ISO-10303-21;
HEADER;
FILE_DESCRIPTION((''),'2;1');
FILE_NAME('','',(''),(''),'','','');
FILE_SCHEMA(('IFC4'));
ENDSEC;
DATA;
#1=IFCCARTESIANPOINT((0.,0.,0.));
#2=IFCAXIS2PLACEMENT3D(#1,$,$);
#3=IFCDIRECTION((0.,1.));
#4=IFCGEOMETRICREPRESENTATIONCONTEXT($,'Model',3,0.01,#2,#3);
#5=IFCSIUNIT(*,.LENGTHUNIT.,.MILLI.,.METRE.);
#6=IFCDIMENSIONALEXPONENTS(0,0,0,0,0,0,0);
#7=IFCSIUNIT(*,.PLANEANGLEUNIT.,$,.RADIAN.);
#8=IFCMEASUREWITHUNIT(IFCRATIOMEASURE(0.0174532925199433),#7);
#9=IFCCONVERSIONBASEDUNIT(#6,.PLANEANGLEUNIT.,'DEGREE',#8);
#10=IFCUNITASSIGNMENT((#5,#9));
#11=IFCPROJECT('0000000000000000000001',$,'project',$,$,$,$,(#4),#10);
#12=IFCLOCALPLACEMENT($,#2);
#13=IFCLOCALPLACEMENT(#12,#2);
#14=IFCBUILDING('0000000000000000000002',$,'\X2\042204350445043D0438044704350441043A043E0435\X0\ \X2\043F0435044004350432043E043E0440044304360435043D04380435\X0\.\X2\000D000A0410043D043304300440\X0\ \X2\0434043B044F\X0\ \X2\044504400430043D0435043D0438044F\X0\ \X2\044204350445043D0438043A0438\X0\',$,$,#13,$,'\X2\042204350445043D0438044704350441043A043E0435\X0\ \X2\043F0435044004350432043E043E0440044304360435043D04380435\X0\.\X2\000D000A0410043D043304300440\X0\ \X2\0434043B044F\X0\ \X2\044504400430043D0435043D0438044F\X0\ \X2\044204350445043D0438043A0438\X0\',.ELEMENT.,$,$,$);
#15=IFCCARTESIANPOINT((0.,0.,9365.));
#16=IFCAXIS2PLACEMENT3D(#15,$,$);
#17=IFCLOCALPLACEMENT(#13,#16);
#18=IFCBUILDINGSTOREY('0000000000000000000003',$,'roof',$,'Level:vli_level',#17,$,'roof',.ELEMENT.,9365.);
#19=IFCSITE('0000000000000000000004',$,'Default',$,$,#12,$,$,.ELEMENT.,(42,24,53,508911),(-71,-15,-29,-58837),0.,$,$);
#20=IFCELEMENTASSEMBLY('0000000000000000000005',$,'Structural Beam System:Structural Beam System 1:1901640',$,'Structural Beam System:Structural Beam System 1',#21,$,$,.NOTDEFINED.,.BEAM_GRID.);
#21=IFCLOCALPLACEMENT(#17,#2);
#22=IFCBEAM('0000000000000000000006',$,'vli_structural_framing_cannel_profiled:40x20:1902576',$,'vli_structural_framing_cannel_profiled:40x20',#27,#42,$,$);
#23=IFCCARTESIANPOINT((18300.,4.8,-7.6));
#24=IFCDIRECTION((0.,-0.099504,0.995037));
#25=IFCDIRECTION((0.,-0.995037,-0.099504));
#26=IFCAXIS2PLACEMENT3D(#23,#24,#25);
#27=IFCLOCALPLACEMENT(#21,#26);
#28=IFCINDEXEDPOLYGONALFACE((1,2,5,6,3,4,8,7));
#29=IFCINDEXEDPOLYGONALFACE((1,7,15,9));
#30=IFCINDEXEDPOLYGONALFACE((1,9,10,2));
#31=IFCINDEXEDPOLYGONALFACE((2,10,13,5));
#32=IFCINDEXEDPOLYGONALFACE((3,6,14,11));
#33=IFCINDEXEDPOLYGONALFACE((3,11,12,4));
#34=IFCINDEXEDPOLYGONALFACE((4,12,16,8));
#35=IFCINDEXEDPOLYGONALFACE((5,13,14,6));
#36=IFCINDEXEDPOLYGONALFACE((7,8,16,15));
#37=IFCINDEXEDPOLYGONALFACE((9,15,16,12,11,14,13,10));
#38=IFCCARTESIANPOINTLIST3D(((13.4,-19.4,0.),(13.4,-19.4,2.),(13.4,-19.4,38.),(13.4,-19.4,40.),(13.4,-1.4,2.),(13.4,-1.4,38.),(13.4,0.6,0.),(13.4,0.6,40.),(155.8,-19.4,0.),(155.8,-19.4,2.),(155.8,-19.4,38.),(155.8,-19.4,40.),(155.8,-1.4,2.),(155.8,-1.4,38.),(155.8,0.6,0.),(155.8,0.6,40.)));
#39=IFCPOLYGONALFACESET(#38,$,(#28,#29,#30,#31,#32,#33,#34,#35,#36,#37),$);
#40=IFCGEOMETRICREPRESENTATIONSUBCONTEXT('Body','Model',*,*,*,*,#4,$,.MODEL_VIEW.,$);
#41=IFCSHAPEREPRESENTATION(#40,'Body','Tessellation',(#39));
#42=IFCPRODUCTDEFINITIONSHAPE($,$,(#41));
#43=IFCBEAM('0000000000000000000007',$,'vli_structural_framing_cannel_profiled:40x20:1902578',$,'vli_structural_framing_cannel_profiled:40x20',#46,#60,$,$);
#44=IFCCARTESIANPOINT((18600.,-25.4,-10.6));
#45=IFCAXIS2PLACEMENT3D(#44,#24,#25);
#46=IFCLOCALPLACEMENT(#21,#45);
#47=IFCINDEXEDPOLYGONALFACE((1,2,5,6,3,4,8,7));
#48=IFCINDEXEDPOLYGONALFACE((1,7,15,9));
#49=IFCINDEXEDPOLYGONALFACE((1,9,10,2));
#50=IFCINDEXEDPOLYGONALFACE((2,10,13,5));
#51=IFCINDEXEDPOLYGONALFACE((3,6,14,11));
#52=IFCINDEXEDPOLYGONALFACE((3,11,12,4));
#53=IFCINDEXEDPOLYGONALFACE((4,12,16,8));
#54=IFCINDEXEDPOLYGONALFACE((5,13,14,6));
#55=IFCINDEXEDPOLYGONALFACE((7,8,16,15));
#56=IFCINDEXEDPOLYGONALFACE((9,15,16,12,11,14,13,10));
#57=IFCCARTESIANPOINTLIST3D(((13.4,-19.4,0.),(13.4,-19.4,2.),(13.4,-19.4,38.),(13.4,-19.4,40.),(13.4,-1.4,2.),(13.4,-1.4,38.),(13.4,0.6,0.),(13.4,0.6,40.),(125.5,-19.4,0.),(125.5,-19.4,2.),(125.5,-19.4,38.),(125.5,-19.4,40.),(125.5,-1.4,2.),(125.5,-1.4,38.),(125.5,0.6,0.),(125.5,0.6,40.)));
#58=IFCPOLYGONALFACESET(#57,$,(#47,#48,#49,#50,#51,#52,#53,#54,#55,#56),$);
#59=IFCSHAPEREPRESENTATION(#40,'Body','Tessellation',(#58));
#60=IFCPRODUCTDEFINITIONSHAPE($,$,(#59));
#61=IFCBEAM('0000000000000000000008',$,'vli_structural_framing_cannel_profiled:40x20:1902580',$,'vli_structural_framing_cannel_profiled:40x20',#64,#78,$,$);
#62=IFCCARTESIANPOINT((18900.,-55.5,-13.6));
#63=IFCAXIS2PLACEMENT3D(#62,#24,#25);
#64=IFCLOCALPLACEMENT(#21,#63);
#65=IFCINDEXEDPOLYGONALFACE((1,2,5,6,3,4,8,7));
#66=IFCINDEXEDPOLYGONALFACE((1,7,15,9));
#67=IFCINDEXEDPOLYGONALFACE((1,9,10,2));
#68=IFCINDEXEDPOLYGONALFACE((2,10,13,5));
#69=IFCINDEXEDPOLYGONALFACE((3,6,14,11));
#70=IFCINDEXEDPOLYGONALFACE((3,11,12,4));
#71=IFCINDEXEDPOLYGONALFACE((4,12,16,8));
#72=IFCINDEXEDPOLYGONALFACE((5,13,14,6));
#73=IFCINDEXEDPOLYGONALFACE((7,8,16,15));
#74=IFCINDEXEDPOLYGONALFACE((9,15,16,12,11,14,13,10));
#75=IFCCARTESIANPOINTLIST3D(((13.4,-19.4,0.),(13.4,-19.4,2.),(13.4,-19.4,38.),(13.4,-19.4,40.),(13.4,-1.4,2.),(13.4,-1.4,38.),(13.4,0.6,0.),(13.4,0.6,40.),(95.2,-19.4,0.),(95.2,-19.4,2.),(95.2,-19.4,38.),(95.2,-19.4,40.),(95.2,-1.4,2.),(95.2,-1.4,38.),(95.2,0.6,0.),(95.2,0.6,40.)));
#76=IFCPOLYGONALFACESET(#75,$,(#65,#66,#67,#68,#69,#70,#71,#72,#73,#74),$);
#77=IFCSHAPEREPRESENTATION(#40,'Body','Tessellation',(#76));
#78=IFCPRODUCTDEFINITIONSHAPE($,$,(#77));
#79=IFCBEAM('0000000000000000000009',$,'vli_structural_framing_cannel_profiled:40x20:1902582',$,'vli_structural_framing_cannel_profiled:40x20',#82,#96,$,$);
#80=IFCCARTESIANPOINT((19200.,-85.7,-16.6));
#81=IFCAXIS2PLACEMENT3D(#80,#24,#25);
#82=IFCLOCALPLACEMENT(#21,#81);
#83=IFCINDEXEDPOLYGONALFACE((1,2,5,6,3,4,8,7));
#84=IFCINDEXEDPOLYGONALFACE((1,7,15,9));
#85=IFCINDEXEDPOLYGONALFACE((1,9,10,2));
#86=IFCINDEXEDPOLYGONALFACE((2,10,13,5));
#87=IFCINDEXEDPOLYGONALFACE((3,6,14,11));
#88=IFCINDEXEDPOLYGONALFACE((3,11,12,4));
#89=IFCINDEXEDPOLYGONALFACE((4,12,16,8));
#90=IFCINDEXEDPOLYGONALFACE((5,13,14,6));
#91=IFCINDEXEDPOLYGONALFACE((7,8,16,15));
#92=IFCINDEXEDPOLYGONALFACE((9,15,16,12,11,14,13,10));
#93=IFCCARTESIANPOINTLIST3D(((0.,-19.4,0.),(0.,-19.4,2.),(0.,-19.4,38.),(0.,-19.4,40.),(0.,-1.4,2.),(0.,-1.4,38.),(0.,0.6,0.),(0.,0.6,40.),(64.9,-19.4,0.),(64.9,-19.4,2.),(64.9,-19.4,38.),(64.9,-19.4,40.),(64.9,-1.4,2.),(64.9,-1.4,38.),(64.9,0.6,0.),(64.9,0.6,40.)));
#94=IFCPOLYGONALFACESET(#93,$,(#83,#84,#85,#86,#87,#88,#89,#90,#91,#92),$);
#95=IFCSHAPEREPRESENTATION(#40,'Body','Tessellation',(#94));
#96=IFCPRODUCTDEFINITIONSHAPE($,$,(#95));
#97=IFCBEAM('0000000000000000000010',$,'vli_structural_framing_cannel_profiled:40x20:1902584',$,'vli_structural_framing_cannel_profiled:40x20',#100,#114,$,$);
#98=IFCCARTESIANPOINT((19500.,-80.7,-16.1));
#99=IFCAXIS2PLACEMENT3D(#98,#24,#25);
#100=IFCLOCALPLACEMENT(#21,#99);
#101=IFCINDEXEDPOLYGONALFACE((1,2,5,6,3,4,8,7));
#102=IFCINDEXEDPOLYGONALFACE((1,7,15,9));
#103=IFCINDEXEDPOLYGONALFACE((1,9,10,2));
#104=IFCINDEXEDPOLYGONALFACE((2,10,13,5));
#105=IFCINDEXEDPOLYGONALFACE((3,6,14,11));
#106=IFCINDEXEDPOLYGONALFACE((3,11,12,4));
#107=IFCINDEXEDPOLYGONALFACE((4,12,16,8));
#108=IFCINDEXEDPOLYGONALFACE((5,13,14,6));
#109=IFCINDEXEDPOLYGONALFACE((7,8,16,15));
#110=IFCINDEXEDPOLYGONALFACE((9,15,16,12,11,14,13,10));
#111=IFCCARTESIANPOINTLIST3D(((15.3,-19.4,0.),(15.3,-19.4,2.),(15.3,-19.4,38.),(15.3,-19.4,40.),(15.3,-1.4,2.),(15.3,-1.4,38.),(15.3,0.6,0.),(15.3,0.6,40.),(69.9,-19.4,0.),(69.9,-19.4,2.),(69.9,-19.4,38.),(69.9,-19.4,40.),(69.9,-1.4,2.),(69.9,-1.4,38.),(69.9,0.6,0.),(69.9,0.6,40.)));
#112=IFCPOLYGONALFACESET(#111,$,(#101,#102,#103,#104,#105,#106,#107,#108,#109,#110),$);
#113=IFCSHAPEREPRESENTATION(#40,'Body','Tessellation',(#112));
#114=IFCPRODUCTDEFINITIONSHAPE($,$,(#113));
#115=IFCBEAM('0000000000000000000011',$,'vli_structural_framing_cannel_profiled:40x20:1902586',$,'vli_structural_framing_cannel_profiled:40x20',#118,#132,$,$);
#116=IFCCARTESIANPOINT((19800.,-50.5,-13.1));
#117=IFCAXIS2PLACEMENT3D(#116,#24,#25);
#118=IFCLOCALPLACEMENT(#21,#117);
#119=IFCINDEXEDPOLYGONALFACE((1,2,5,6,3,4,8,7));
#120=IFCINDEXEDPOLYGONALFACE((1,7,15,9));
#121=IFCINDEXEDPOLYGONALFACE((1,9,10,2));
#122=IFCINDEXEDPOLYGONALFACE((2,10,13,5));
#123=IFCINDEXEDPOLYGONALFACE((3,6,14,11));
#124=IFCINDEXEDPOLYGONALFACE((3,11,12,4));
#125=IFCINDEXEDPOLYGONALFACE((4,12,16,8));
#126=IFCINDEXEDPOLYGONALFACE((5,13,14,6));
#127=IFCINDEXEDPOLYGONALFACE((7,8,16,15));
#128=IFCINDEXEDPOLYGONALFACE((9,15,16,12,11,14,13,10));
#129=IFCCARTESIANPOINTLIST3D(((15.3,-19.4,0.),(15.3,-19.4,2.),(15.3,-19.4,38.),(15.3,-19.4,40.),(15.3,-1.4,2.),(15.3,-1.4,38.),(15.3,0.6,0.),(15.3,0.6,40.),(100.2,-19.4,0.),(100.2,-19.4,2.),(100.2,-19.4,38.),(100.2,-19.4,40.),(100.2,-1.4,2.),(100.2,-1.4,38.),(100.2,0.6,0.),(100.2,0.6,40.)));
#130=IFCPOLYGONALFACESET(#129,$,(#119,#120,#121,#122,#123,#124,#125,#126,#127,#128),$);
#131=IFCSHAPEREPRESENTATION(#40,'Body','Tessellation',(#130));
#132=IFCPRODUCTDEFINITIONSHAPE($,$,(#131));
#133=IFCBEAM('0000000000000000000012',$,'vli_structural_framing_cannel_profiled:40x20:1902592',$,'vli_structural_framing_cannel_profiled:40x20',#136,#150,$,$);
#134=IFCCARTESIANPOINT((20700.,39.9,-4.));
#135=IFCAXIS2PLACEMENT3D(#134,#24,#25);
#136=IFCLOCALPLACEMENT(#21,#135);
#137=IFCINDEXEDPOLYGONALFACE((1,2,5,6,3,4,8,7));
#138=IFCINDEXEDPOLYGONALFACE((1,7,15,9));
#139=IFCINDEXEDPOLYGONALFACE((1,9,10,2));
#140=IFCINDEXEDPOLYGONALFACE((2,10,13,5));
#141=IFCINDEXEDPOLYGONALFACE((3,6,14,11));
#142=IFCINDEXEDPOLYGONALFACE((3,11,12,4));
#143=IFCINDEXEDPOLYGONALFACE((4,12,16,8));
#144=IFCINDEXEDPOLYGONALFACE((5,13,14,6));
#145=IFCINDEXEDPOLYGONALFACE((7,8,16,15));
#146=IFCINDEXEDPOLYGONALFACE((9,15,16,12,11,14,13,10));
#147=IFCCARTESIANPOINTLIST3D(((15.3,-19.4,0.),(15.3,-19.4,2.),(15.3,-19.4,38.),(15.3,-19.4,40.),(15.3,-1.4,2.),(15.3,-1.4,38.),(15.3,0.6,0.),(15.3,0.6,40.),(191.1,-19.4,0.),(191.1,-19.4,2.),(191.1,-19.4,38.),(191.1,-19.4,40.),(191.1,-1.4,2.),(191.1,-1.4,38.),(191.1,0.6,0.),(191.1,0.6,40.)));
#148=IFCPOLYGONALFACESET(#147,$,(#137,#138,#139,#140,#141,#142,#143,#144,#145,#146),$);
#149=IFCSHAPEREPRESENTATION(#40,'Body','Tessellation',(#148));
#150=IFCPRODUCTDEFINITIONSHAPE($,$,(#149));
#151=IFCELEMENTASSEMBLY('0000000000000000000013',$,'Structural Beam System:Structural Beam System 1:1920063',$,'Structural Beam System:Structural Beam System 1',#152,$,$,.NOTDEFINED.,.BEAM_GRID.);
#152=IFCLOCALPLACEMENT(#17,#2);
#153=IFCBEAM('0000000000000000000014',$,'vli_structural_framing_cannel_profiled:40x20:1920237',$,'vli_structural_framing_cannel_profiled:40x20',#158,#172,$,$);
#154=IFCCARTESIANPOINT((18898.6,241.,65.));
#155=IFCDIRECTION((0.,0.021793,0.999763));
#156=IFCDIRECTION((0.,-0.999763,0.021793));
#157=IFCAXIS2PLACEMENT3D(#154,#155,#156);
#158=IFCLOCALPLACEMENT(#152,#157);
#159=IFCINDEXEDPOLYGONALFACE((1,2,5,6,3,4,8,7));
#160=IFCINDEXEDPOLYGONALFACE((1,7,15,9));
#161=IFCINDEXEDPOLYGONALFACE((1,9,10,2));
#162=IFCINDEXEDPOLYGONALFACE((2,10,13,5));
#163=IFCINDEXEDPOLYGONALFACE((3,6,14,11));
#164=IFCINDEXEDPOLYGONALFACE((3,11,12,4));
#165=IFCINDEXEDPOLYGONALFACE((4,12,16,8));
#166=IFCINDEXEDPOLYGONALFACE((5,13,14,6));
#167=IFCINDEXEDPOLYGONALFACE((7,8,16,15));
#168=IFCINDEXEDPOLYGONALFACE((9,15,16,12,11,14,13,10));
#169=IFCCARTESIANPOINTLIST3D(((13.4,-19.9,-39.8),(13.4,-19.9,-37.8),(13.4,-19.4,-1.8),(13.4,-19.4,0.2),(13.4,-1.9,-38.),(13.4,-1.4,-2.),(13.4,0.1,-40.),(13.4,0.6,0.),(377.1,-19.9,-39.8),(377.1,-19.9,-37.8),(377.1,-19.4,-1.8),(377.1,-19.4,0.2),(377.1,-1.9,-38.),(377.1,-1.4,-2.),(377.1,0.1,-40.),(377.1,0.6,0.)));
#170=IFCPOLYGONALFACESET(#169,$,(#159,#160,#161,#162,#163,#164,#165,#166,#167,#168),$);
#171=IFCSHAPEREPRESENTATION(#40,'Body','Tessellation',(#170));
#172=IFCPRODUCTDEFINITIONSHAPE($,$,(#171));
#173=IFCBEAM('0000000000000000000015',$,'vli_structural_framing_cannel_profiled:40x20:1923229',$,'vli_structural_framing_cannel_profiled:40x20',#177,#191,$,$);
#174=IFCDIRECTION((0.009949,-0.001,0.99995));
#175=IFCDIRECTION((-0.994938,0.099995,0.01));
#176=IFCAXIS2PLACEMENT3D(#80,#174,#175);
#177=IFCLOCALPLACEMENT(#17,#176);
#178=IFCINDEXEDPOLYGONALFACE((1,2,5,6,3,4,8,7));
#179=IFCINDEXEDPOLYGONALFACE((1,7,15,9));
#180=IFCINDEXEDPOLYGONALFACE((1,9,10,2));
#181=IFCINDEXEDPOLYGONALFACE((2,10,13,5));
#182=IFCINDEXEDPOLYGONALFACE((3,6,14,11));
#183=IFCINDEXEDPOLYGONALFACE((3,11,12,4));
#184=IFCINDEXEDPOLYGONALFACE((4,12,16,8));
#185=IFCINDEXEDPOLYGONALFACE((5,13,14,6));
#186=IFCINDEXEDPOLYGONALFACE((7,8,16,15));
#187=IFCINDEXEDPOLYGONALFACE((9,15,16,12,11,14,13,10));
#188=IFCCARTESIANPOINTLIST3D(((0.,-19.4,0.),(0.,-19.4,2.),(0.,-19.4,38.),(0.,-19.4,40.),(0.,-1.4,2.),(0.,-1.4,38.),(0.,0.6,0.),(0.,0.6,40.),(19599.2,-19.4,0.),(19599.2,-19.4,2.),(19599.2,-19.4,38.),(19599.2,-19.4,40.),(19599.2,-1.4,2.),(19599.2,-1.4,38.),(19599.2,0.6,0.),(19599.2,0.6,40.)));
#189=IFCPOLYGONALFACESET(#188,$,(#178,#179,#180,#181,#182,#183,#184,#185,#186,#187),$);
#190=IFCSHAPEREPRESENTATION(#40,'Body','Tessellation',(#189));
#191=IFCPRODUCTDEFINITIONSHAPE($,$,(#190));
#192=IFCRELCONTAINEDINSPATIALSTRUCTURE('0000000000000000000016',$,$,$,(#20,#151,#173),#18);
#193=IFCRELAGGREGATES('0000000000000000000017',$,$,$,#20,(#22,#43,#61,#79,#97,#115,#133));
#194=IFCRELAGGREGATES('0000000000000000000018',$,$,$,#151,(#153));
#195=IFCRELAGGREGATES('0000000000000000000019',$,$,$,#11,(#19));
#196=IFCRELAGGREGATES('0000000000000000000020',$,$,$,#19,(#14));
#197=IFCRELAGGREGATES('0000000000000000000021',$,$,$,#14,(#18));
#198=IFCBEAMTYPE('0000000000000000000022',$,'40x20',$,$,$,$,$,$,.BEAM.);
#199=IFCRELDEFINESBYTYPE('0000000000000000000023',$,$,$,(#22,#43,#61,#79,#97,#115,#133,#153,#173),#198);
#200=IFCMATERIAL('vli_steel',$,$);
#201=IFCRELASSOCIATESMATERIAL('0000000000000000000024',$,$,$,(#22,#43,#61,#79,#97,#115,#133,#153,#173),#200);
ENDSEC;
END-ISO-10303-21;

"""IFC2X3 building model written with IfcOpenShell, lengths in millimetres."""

from ifc_helpers import new_model, entity, si_unit, converted_unit, direction, frame, origin, place, context, subcontext, project, spatial, polyline, outline, extrude, material, type_object, element, aggregate, save


model = new_model("IFC2X3")

# Units and contexts
model_context = context("Model", 3, precision=0.01, world=origin(), true_north=direction((0.0, 1.0)))
body_context = subcontext(model_context, "Body", "Model", "MODEL_VIEW")
ifc_project = project(units=[si_unit("LENGTHUNIT", "METRE", prefix="MILLI"), converted_unit("PLANEANGLEUNIT", "DEGREE", entity("IfcRatioMeasure", 0.0174532925199433), si_unit("PLANEANGLEUNIT", "RADIAN"), dimensions=[0, 0, 0, 0, 0, 0, 0])], contexts=[model_context])

# Site, building, storey
site_placement = place(None, origin())
site = spatial("IfcSite", under=ifc_project, at=site_placement, Name="Default", CompositionType="ELEMENT", RefLatitude=(42, 24, 53, 508911), RefLongitude=(-71, -15, -29, -58837), RefElevation=0.0)
building_placement = place(site_placement, origin())
building = spatial("IfcBuilding", under=site, at=building_placement, Name="Техническое перевооружение.\r\nАнгар для хранения техники", LongName="Техническое перевооружение.\r\nАнгар для хранения техники", CompositionType="ELEMENT")
storey_placement = place(building_placement, frame((0.0, 0.0, 9365.0)))
storey = spatial("IfcBuildingStorey", under=building, at=storey_placement, Name="roof", ObjectType="Level:vli_level", LongName="roof", CompositionType="ELEMENT", Elevation=9365.0)

# Element assemblies, beams
assembly_1_placement = place(storey_placement, origin())
assembly_1 = element("IfcElementAssembly", 1, at=assembly_1_placement, inside=storey, Name="Structural Beam System:Structural Beam System 1:1901640", ObjectType="Structural Beam System:Structural Beam System 1", AssemblyPlace="NOTDEFINED", PredefinedType="BEAM_GRID")
ifc_material = material(Name="vli_steel")
beam_type = type_object("IfcBeamType", Name="40x20", PredefinedType="BEAM")
beam_1_placement = place(assembly_1_placement, frame((18300.0, 4.8, -7.6), z_axis=(0.0, -0.099504, 0.995037), x_axis=(0.0, -0.995037, -0.099504)))
beam_1 = element("IfcBeam", 2, at=beam_1_placement, type_object=beam_type, material=ifc_material, Name="vli_structural_framing_cannel_profiled:40x20:1902576", ObjectType="vli_structural_framing_cannel_profiled:40x20", context=body_context, shape_type="SweptSolid", body=[
    extrude(outline(polyline([(-20.0, -9.5), (-18.0, -9.5), (-18.0, 8.5), (18.0, 8.5), (18.0, -9.5), (20.0, -9.5), (20.0, 10.5), (-20.0, 10.5), (-20.0, -9.5)])), frame((13.4, -9.9, 20.0), z_axis=(1.0, 0.0, 0.0), x_axis=(0.0, 0.0, -1.0)), (0.0, 0.0, 1.0), 142.4),
])
beam_2_placement = place(assembly_1_placement, frame((18600.0, -25.4, -10.6), z_axis=(0.0, -0.099504, 0.995037), x_axis=(0.0, -0.995037, -0.099504)))
beam_2 = element("IfcBeam", 3, at=beam_2_placement, type_object=beam_type, material=ifc_material, Name="vli_structural_framing_cannel_profiled:40x20:1902578", ObjectType="vli_structural_framing_cannel_profiled:40x20", context=body_context, shape_type="SweptSolid", body=[
    extrude(outline(polyline([(-20.0, -9.5), (-18.0, -9.5), (-18.0, 8.5), (18.0, 8.5), (18.0, -9.5), (20.0, -9.5), (20.0, 10.5), (-20.0, 10.5), (-20.0, -9.5)])), frame((13.4, -9.9, 20.0), z_axis=(1.0, 0.0, 0.0), x_axis=(0.0, 0.0, -1.0)), (0.0, 0.0, 1.0), 112.1),
])
beam_3_placement = place(assembly_1_placement, frame((18900.0, -55.5, -13.6), z_axis=(0.0, -0.099504, 0.995037), x_axis=(0.0, -0.995037, -0.099504)))
beam_3 = element("IfcBeam", 4, at=beam_3_placement, type_object=beam_type, material=ifc_material, Name="vli_structural_framing_cannel_profiled:40x20:1902580", ObjectType="vli_structural_framing_cannel_profiled:40x20", context=body_context, shape_type="SweptSolid", body=[
    extrude(outline(polyline([(-20.0, -9.5), (-18.0, -9.5), (-18.0, 8.5), (18.0, 8.5), (18.0, -9.5), (20.0, -9.5), (20.0, 10.5), (-20.0, 10.5), (-20.0, -9.5)])), frame((13.4, -9.9, 20.0), z_axis=(1.0, 0.0, 0.0), x_axis=(0.0, 0.0, -1.0)), (0.0, 0.0, 1.0), 81.8),
])
beam_4_placement = place(assembly_1_placement, frame((19200.0, -85.7, -16.6), z_axis=(0.0, -0.099504, 0.995037), x_axis=(0.0, -0.995037, -0.099504)))
beam_4 = element("IfcBeam", 5, at=beam_4_placement, type_object=beam_type, material=ifc_material, Name="vli_structural_framing_cannel_profiled:40x20:1902582", ObjectType="vli_structural_framing_cannel_profiled:40x20", context=body_context, shape_type="SweptSolid", body=[
    extrude(outline(polyline([(-20.0, -9.5), (-18.0, -9.5), (-18.0, 8.5), (18.0, 8.5), (18.0, -9.5), (20.0, -9.5), (20.0, 10.5), (-20.0, 10.5), (-20.0, -9.5)])), frame((0.0, -9.9, 20.0), z_axis=(1.0, 0.0, 0.0), x_axis=(0.0, 0.0, -1.0)), (0.0, 0.0, 1.0), 64.9),
])
beam_5_placement = place(assembly_1_placement, frame((19500.0, -80.7, -16.1), z_axis=(0.0, -0.099504, 0.995037), x_axis=(0.0, -0.995037, -0.099504)))
beam_5 = element("IfcBeam", 6, at=beam_5_placement, type_object=beam_type, material=ifc_material, Name="vli_structural_framing_cannel_profiled:40x20:1902584", ObjectType="vli_structural_framing_cannel_profiled:40x20", context=body_context, shape_type="SweptSolid", body=[
    extrude(outline(polyline([(-20.0, -9.5), (-18.0, -9.5), (-18.0, 8.5), (18.0, 8.5), (18.0, -9.5), (20.0, -9.5), (20.0, 10.5), (-20.0, 10.5), (-20.0, -9.5)])), frame((15.3, -9.9, 20.0), z_axis=(1.0, 0.0, 0.0), x_axis=(0.0, 0.0, -1.0)), (0.0, 0.0, 1.0), 54.7),
])
beam_6_placement = place(assembly_1_placement, frame((19800.0, -50.5, -13.1), z_axis=(0.0, -0.099504, 0.995037), x_axis=(0.0, -0.995037, -0.099504)))
beam_6 = element("IfcBeam", 7, at=beam_6_placement, type_object=beam_type, material=ifc_material, Name="vli_structural_framing_cannel_profiled:40x20:1902586", ObjectType="vli_structural_framing_cannel_profiled:40x20", context=body_context, shape_type="SweptSolid", body=[
    extrude(outline(polyline([(-20.0, -9.5), (-18.0, -9.5), (-18.0, 8.5), (18.0, 8.5), (18.0, -9.5), (20.0, -9.5), (20.0, 10.5), (-20.0, 10.5), (-20.0, -9.5)])), frame((15.3, -9.9, 20.0), z_axis=(1.0, 0.0, 0.0), x_axis=(0.0, 0.0, -1.0)), (0.0, 0.0, 1.0), 85.0),
])
beam_7_placement = place(assembly_1_placement, frame((20700.0, 39.9, -4.0), z_axis=(0.0, -0.099504, 0.995037), x_axis=(0.0, -0.995037, -0.099504)))
beam_7 = element("IfcBeam", 8, at=beam_7_placement, type_object=beam_type, material=ifc_material, Name="vli_structural_framing_cannel_profiled:40x20:1902592", ObjectType="vli_structural_framing_cannel_profiled:40x20", context=body_context, shape_type="SweptSolid", body=[
    extrude(outline(polyline([(-20.0, -9.5), (-18.0, -9.5), (-18.0, 8.5), (18.0, 8.5), (18.0, -9.5), (20.0, -9.5), (20.0, 10.5), (-20.0, 10.5), (-20.0, -9.5)])), frame((15.3, -9.9, 20.0), z_axis=(1.0, 0.0, 0.0), x_axis=(0.0, 0.0, -1.0)), (0.0, 0.0, 1.0), 175.9),
])
aggregate(assembly_1, [beam_1, beam_2, beam_3, beam_4, beam_5, beam_6, beam_7])
assembly_2_placement = place(storey_placement, origin())
assembly_2 = element("IfcElementAssembly", 9, at=assembly_2_placement, inside=storey, Name="Structural Beam System:Structural Beam System 1:1920063", ObjectType="Structural Beam System:Structural Beam System 1", AssemblyPlace="NOTDEFINED", PredefinedType="BEAM_GRID")
beam_8_placement = place(assembly_2_placement, frame((18898.6, 241.0, 65.0), z_axis=(0.0, 0.021793, 0.999763), x_axis=(0.0, -0.999763, 0.021793)))
beam_8 = element("IfcBeam", 10, at=beam_8_placement, type_object=beam_type, material=ifc_material, Name="vli_structural_framing_cannel_profiled:40x20:1920237", ObjectType="vli_structural_framing_cannel_profiled:40x20", context=body_context, shape_type="SweptSolid", body=[
    extrude(outline(polyline([(-10.5, -20.0), (9.5, -20.0), (9.5, -18.0), (-8.5, -18.0), (-8.5, 18.0), (9.5, 18.0), (9.5, 20.0), (-10.5, 20.0), (-10.5, -20.0)])), frame((13.4, -10.1, -19.9), z_axis=(1.0, 0.0, 0.0), x_axis=(0.0, -0.999925, 0.012237)), (0.0, 0.0, 1.0), 363.7),
])

# Beam
beam_9_placement = place(storey_placement, frame((19200.0, -85.7, -16.6), z_axis=(0.009949, -0.001, 0.99995), x_axis=(-0.994938, 0.099995, 0.01)))
element("IfcBeam", 11, at=beam_9_placement, inside=storey, type_object=beam_type, material=ifc_material, Name="vli_structural_framing_cannel_profiled:40x20:1923229", ObjectType="vli_structural_framing_cannel_profiled:40x20", context=body_context, shape_type="SweptSolid", body=[
    extrude(outline(polyline([(-20.0, -9.5), (-18.0, -9.5), (-18.0, 8.5), (18.0, 8.5), (18.0, -9.5), (20.0, -9.5), (20.0, 10.5), (-20.0, 10.5), (-20.0, -9.5)])), frame((0.0, -9.9, 20.0), z_axis=(1.0, 0.0, 0.0), x_axis=(0.0, 0.0, -1.0)), (0.0, 0.0, 1.0), 19599.2),
])

aggregate(assembly_2, [beam_8])

save(model, "model.ifc")
